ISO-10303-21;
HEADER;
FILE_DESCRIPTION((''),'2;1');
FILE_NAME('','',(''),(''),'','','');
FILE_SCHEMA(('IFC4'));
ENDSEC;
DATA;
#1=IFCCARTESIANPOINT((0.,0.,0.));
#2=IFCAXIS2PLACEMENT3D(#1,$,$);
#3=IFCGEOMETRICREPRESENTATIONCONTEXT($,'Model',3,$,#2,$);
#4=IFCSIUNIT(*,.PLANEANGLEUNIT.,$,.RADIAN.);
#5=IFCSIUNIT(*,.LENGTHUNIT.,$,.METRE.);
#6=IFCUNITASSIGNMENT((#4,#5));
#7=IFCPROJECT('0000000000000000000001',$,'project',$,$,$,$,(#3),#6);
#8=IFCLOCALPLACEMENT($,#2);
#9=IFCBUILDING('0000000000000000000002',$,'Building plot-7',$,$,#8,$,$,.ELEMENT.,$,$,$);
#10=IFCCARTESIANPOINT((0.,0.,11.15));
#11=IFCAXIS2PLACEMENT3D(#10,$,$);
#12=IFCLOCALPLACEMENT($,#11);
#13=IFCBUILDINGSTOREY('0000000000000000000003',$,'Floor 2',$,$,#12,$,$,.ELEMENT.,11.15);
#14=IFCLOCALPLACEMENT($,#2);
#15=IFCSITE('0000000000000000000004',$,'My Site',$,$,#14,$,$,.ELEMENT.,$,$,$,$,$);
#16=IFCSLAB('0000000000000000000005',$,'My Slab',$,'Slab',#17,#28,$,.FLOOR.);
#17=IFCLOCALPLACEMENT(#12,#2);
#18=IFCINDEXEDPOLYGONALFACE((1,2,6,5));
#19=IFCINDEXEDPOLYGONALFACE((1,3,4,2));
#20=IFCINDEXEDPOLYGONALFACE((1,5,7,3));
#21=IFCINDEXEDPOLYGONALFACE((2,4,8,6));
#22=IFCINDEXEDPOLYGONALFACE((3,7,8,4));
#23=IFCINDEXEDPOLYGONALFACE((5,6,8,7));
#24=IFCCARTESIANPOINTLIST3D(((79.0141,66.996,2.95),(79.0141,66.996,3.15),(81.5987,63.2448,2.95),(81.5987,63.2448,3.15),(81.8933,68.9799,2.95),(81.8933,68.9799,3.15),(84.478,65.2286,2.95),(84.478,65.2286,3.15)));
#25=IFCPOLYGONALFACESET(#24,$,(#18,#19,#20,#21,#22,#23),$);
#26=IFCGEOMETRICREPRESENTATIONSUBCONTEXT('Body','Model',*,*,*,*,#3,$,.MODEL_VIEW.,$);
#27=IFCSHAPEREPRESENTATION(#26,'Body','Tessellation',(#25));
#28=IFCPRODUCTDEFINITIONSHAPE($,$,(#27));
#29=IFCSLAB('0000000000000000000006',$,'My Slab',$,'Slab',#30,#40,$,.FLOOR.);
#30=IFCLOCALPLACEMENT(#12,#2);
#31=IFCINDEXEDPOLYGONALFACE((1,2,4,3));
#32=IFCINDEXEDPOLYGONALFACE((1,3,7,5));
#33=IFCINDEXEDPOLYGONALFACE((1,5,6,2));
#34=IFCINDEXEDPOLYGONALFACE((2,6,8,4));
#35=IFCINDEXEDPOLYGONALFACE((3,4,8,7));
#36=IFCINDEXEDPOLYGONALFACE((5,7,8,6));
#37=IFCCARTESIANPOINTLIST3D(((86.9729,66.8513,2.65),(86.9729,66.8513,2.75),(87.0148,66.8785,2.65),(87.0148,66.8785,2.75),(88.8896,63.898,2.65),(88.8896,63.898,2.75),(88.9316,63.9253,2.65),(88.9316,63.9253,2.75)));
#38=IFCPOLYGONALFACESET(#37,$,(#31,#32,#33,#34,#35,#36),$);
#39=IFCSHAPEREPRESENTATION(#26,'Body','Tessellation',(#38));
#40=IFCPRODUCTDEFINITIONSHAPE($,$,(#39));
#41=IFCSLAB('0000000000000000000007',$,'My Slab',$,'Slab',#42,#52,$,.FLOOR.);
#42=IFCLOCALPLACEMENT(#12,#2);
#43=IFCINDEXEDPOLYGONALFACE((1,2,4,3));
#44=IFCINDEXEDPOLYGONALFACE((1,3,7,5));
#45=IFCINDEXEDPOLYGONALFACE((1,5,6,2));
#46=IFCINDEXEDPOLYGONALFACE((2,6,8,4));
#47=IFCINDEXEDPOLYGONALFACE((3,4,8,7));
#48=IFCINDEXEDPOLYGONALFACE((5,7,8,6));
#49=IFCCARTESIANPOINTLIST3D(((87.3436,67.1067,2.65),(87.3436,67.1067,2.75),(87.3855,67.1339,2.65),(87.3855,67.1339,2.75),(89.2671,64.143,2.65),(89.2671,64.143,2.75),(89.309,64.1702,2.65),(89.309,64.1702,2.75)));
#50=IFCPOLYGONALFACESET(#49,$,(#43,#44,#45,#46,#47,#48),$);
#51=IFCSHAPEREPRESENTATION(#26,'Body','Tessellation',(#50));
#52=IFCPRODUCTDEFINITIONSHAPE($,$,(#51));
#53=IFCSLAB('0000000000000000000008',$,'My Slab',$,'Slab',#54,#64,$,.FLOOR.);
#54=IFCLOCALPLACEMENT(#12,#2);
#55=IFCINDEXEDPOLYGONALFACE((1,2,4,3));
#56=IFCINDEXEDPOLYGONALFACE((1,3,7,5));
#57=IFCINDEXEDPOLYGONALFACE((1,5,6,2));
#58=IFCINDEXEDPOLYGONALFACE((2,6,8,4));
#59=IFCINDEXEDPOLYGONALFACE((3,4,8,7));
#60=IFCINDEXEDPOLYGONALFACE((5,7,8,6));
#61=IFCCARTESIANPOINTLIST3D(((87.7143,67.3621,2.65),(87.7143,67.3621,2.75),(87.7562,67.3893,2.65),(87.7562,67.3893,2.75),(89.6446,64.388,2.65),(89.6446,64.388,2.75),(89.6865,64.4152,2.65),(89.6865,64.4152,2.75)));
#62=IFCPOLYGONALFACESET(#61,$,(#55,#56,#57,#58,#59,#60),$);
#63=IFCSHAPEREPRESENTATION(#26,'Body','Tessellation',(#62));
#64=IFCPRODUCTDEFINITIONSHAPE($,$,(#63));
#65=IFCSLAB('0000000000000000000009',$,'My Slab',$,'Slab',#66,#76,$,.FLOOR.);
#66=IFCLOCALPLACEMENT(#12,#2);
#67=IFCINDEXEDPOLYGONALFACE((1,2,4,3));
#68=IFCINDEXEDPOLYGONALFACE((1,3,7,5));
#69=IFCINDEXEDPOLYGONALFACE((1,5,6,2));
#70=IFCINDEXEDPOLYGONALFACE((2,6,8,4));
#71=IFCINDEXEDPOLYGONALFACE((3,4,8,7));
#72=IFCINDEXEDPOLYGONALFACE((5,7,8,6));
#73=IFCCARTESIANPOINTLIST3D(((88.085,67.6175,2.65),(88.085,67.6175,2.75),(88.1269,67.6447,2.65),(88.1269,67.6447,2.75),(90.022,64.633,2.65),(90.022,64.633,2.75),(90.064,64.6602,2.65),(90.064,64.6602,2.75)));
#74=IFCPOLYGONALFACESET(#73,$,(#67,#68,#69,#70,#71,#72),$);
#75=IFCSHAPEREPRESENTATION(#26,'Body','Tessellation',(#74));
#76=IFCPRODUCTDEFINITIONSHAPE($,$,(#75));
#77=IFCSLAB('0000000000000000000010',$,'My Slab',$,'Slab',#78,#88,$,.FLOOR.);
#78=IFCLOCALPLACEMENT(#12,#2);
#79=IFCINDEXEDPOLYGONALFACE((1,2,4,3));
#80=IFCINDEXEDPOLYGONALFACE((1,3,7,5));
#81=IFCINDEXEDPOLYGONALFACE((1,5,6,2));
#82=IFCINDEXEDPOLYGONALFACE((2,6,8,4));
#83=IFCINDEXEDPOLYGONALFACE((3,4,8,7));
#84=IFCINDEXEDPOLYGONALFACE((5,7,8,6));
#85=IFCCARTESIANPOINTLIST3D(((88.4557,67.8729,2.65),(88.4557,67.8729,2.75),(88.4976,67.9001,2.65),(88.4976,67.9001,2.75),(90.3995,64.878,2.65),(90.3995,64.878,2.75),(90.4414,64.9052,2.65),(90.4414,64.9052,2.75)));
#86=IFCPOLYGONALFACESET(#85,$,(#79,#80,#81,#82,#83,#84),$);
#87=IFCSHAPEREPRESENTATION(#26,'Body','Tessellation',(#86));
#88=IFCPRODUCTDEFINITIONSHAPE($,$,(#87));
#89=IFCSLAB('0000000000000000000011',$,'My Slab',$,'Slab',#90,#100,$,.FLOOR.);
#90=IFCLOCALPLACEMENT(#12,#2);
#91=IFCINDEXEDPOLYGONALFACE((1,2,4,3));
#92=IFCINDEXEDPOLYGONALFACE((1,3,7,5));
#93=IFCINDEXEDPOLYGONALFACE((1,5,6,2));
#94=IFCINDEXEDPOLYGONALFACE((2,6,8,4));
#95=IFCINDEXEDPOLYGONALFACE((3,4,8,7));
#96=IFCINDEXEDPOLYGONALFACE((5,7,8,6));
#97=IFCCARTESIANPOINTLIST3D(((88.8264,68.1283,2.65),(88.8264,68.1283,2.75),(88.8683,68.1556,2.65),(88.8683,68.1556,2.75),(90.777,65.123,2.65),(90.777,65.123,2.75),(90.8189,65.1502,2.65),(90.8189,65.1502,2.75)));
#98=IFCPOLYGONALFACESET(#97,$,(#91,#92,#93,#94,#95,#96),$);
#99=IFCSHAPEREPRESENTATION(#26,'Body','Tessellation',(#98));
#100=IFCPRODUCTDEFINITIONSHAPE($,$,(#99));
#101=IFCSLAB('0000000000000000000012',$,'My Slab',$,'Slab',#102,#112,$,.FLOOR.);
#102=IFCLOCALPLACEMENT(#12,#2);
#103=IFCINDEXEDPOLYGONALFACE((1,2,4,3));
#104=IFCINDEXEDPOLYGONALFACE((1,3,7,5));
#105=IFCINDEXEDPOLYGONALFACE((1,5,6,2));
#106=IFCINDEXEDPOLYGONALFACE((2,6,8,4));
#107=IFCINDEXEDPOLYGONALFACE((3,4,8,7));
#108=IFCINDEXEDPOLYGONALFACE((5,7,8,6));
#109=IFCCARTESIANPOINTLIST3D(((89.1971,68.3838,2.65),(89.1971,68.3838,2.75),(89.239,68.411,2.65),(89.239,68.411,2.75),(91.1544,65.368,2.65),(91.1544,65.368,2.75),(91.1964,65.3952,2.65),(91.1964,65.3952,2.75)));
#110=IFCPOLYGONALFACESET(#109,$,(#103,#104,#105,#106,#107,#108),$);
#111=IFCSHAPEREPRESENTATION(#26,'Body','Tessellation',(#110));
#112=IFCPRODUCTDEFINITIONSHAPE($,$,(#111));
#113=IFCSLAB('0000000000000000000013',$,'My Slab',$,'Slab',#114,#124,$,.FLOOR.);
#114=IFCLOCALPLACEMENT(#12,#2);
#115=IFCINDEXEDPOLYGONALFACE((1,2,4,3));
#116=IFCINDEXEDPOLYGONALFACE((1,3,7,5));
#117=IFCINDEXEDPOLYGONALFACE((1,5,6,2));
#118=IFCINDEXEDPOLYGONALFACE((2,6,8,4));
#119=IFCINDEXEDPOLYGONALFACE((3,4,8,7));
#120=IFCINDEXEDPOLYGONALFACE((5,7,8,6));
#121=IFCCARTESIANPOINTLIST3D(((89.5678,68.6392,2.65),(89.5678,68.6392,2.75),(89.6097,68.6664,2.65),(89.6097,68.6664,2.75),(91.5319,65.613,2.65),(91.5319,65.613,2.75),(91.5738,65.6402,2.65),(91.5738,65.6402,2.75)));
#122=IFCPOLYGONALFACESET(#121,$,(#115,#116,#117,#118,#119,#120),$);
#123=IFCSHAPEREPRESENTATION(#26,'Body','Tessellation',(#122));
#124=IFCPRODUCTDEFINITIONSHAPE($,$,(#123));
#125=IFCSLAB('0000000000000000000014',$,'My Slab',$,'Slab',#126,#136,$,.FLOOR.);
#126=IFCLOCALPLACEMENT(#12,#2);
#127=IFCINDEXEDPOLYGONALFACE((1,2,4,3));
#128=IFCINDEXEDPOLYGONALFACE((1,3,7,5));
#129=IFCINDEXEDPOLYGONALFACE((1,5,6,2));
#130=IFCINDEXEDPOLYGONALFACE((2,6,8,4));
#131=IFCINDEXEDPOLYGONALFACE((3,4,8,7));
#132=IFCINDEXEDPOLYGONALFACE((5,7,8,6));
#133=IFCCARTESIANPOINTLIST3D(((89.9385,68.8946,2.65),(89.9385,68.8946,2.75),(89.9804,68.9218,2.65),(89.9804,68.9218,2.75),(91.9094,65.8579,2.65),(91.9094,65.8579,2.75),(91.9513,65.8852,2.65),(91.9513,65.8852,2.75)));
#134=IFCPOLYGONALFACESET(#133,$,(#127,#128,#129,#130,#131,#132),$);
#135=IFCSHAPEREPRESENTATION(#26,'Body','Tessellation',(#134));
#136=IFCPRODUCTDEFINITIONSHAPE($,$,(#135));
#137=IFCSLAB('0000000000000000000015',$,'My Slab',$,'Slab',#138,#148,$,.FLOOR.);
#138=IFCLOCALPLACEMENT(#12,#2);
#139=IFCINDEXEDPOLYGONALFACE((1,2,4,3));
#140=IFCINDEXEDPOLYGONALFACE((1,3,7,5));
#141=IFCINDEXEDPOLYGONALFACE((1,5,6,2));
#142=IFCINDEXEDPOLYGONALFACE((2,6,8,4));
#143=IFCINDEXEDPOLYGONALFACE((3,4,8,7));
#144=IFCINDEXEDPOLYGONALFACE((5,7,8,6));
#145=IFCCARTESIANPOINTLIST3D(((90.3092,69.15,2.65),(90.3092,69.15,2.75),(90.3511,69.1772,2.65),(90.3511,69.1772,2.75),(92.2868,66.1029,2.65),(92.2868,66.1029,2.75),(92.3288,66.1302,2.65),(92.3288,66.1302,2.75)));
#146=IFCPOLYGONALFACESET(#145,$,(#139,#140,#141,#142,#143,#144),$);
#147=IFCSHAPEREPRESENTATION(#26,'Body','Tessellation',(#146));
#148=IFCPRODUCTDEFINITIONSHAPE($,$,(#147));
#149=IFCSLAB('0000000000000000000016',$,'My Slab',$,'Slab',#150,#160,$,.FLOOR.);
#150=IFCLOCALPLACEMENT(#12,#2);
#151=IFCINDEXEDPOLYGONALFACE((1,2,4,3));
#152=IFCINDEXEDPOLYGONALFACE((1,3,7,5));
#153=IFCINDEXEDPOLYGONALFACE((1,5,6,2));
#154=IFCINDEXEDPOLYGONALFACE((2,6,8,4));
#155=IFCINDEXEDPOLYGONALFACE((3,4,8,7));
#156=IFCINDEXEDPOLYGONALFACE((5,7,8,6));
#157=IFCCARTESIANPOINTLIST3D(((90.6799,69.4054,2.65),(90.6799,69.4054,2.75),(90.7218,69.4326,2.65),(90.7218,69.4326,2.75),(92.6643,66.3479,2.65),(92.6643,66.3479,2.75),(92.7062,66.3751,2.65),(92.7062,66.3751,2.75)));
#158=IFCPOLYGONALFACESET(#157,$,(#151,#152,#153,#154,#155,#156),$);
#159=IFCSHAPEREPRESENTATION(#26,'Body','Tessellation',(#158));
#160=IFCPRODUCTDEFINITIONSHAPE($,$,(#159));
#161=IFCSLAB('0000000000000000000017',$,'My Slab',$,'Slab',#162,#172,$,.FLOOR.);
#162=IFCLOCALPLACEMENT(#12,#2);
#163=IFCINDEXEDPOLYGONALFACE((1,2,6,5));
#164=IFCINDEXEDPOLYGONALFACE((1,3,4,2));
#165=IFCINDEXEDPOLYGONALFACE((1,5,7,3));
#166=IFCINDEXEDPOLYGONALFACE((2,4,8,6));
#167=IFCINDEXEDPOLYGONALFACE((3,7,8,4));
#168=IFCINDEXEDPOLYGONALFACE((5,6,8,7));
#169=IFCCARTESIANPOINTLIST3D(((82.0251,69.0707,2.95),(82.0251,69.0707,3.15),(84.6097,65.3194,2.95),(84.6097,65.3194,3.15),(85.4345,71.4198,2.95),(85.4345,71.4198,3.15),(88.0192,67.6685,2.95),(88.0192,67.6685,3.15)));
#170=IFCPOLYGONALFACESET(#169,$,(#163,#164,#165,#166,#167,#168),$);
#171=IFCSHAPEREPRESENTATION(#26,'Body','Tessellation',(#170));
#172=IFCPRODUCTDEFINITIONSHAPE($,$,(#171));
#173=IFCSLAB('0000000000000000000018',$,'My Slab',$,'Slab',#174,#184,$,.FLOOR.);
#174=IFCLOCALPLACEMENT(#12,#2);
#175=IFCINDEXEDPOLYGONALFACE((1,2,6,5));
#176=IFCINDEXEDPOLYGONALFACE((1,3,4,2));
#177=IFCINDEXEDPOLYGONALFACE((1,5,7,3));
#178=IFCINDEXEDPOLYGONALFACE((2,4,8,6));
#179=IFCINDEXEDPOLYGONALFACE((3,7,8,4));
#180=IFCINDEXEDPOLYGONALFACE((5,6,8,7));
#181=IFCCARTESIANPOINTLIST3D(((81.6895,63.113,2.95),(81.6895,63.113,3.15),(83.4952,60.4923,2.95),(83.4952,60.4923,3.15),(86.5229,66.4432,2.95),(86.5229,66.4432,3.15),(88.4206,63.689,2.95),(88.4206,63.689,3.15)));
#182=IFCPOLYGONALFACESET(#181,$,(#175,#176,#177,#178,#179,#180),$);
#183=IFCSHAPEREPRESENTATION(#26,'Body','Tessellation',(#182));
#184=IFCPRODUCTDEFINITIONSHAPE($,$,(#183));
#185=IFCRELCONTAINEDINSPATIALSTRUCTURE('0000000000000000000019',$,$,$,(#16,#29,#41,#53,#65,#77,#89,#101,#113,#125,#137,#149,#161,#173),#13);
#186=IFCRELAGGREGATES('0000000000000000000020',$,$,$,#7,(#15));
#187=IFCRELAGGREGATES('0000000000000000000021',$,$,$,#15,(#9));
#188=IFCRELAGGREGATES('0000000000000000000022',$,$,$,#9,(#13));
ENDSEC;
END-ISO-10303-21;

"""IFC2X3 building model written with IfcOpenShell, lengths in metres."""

from ifc_helpers import new_model, si_unit, frame, origin, place, context, subcontext, project, spatial, polyline, outline, extrude, element, save


model = new_model("IFC2X3")

# Units and contexts
model_context = context("Model", 3, world=origin())
body_context = subcontext(model_context, "Body", "Model", "MODEL_VIEW")
ifc_project = project(units=[si_unit("PLANEANGLEUNIT", "RADIAN"), si_unit("LENGTHUNIT", "METRE")], contexts=[model_context])

# Site, building, storey
site_placement = place(None, origin())
site = spatial("IfcSite", under=ifc_project, at=site_placement, Name="My Site", CompositionType="ELEMENT")
building_placement = place(None, origin())
building = spatial("IfcBuilding", under=site, at=building_placement, Name="Building plot-7", CompositionType="ELEMENT")
storey_placement = place(None, frame((0.0, 0.0, 11.15)))
storey = spatial("IfcBuildingStorey", under=building, at=storey_placement, Name="Floor 2", CompositionType="ELEMENT", Elevation=11.15)

# Slabs
slab_1_placement = place(storey_placement, frame((0.0, 0.0, 2.95)))
element("IfcSlab", 1, at=slab_1_placement, inside=storey, Name="My Slab", ObjectType="Slab", PredefinedType="FLOOR", context=body_context, shape_type="SweptSolid", body=[
    extrude(outline(polyline([(81.8933, 68.9799), (79.0141, 66.996), (81.5987, 63.2448), (84.478, 65.2286), (81.8933, 68.9799)])), origin(), (0.0, 0.0, 1.0), 0.2),
])
slab_2_placement = place(storey_placement, frame((0.0, 0.0, 2.65)))
element("IfcSlab", 2, at=slab_2_placement, inside=storey, Name="My Slab", ObjectType="Slab", PredefinedType="FLOOR", context=body_context, shape_type="SweptSolid", body=[
    extrude(outline(polyline([(88.8896, 63.898), (88.9316, 63.9253), (87.0148, 66.8785), (86.9729, 66.8513), (88.8896, 63.898)])), origin(), (0.0, 0.0, 1.0), 0.1),
])
slab_3_placement = place(storey_placement, frame((0.0, 0.0, 2.65)))
element("IfcSlab", 3, at=slab_3_placement, inside=storey, Name="My Slab", ObjectType="Slab", PredefinedType="FLOOR", context=body_context, shape_type="SweptSolid", body=[
    extrude(outline(polyline([(89.2671, 64.143), (89.309, 64.1702), (87.3855, 67.1339), (87.3436, 67.1067), (89.2671, 64.143)])), origin(), (0.0, 0.0, 1.0), 0.1),
])
slab_4_placement = place(storey_placement, frame((0.0, 0.0, 2.65)))
element("IfcSlab", 4, at=slab_4_placement, inside=storey, Name="My Slab", ObjectType="Slab", PredefinedType="FLOOR", context=body_context, shape_type="SweptSolid", body=[
    extrude(outline(polyline([(89.6446, 64.388), (89.6865, 64.4152), (87.7562, 67.3893), (87.7143, 67.3621), (89.6446, 64.388)])), origin(), (0.0, 0.0, 1.0), 0.1),
])
slab_5_placement = place(storey_placement, frame((0.0, 0.0, 2.65)))
element("IfcSlab", 5, at=slab_5_placement, inside=storey, Name="My Slab", ObjectType="Slab", PredefinedType="FLOOR", context=body_context, shape_type="SweptSolid", body=[
    extrude(outline(polyline([(90.022, 64.633), (90.064, 64.6602), (88.1269, 67.6447), (88.085, 67.6175), (90.022, 64.633)])), origin(), (0.0, 0.0, 1.0), 0.1),
])
slab_6_placement = place(storey_placement, frame((0.0, 0.0, 2.65)))
element("IfcSlab", 6, at=slab_6_placement, inside=storey, Name="My Slab", ObjectType="Slab", PredefinedType="FLOOR", context=body_context, shape_type="SweptSolid", body=[
    extrude(outline(polyline([(90.3995, 64.878), (90.4414, 64.9052), (88.4976, 67.9001), (88.4557, 67.8729), (90.3995, 64.878)])), origin(), (0.0, 0.0, 1.0), 0.1),
])
slab_7_placement = place(storey_placement, frame((0.0, 0.0, 2.65)))
element("IfcSlab", 7, at=slab_7_placement, inside=storey, Name="My Slab", ObjectType="Slab", PredefinedType="FLOOR", context=body_context, shape_type="SweptSolid", body=[
    extrude(outline(polyline([(90.777, 65.123), (90.8189, 65.1502), (88.8683, 68.1556), (88.8264, 68.1283), (90.777, 65.123)])), origin(), (0.0, 0.0, 1.0), 0.1),
])
slab_8_placement = place(storey_placement, frame((0.0, 0.0, 2.65)))
element("IfcSlab", 8, at=slab_8_placement, inside=storey, Name="My Slab", ObjectType="Slab", PredefinedType="FLOOR", context=body_context, shape_type="SweptSolid", body=[
    extrude(outline(polyline([(91.1544, 65.368), (91.1964, 65.3952), (89.239, 68.411), (89.1971, 68.3838), (91.1544, 65.368)])), origin(), (0.0, 0.0, 1.0), 0.1),
])
slab_9_placement = place(storey_placement, frame((0.0, 0.0, 2.65)))
element("IfcSlab", 9, at=slab_9_placement, inside=storey, Name="My Slab", ObjectType="Slab", PredefinedType="FLOOR", context=body_context, shape_type="SweptSolid", body=[
    extrude(outline(polyline([(91.5319, 65.613), (91.5738, 65.6402), (89.6097, 68.6664), (89.5678, 68.6392), (91.5319, 65.613)])), origin(), (0.0, 0.0, 1.0), 0.1),
])
slab_10_placement = place(storey_placement, frame((0.0, 0.0, 2.65)))
element("IfcSlab", 10, at=slab_10_placement, inside=storey, Name="My Slab", ObjectType="Slab", PredefinedType="FLOOR", context=body_context, shape_type="SweptSolid", body=[
    extrude(outline(polyline([(91.9094, 65.8579), (91.9513, 65.8852), (89.9804, 68.9218), (89.9385, 68.8946), (91.9094, 65.8579)])), origin(), (0.0, 0.0, 1.0), 0.1),
])
slab_11_placement = place(storey_placement, frame((0.0, 0.0, 2.65)))
element("IfcSlab", 11, at=slab_11_placement, inside=storey, Name="My Slab", ObjectType="Slab", PredefinedType="FLOOR", context=body_context, shape_type="SweptSolid", body=[
    extrude(outline(polyline([(92.2868, 66.1029), (92.3288, 66.1302), (90.3511, 69.1772), (90.3092, 69.15), (92.2868, 66.1029)])), origin(), (0.0, 0.0, 1.0), 0.1),
])
slab_12_placement = place(storey_placement, frame((0.0, 0.0, 2.65)))
element("IfcSlab", 12, at=slab_12_placement, inside=storey, Name="My Slab", ObjectType="Slab", PredefinedType="FLOOR", context=body_context, shape_type="SweptSolid", body=[
    extrude(outline(polyline([(92.6643, 66.3479), (92.7062, 66.3751), (90.7218, 69.4326), (90.6799, 69.4054), (92.6643, 66.3479)])), origin(), (0.0, 0.0, 1.0), 0.1),
])
slab_13_placement = place(storey_placement, frame((0.0, 0.0, 2.95)))
element("IfcSlab", 13, at=slab_13_placement, inside=storey, Name="My Slab", ObjectType="Slab", PredefinedType="FLOOR", context=body_context, shape_type="SweptSolid", body=[
    extrude(outline(polyline([(84.6097, 65.3194), (88.0192, 67.6685), (85.4345, 71.4198), (82.0251, 69.0707), (84.6097, 65.3194)])), origin(), (0.0, 0.0, 1.0), 0.2),
])
slab_14_placement = place(storey_placement, frame((0.0, 0.0, 2.95)))
element("IfcSlab", 14, at=slab_14_placement, inside=storey, Name="My Slab", ObjectType="Slab", PredefinedType="FLOOR", context=body_context, shape_type="SweptSolid", body=[
    extrude(outline(polyline([(83.4952, 60.4923), (88.4206, 63.689), (86.5229, 66.4432), (81.6895, 63.113), (83.4952, 60.4923)])), origin(), (0.0, 0.0, 1.0), 0.2),
])

save(model, "model.ifc")
